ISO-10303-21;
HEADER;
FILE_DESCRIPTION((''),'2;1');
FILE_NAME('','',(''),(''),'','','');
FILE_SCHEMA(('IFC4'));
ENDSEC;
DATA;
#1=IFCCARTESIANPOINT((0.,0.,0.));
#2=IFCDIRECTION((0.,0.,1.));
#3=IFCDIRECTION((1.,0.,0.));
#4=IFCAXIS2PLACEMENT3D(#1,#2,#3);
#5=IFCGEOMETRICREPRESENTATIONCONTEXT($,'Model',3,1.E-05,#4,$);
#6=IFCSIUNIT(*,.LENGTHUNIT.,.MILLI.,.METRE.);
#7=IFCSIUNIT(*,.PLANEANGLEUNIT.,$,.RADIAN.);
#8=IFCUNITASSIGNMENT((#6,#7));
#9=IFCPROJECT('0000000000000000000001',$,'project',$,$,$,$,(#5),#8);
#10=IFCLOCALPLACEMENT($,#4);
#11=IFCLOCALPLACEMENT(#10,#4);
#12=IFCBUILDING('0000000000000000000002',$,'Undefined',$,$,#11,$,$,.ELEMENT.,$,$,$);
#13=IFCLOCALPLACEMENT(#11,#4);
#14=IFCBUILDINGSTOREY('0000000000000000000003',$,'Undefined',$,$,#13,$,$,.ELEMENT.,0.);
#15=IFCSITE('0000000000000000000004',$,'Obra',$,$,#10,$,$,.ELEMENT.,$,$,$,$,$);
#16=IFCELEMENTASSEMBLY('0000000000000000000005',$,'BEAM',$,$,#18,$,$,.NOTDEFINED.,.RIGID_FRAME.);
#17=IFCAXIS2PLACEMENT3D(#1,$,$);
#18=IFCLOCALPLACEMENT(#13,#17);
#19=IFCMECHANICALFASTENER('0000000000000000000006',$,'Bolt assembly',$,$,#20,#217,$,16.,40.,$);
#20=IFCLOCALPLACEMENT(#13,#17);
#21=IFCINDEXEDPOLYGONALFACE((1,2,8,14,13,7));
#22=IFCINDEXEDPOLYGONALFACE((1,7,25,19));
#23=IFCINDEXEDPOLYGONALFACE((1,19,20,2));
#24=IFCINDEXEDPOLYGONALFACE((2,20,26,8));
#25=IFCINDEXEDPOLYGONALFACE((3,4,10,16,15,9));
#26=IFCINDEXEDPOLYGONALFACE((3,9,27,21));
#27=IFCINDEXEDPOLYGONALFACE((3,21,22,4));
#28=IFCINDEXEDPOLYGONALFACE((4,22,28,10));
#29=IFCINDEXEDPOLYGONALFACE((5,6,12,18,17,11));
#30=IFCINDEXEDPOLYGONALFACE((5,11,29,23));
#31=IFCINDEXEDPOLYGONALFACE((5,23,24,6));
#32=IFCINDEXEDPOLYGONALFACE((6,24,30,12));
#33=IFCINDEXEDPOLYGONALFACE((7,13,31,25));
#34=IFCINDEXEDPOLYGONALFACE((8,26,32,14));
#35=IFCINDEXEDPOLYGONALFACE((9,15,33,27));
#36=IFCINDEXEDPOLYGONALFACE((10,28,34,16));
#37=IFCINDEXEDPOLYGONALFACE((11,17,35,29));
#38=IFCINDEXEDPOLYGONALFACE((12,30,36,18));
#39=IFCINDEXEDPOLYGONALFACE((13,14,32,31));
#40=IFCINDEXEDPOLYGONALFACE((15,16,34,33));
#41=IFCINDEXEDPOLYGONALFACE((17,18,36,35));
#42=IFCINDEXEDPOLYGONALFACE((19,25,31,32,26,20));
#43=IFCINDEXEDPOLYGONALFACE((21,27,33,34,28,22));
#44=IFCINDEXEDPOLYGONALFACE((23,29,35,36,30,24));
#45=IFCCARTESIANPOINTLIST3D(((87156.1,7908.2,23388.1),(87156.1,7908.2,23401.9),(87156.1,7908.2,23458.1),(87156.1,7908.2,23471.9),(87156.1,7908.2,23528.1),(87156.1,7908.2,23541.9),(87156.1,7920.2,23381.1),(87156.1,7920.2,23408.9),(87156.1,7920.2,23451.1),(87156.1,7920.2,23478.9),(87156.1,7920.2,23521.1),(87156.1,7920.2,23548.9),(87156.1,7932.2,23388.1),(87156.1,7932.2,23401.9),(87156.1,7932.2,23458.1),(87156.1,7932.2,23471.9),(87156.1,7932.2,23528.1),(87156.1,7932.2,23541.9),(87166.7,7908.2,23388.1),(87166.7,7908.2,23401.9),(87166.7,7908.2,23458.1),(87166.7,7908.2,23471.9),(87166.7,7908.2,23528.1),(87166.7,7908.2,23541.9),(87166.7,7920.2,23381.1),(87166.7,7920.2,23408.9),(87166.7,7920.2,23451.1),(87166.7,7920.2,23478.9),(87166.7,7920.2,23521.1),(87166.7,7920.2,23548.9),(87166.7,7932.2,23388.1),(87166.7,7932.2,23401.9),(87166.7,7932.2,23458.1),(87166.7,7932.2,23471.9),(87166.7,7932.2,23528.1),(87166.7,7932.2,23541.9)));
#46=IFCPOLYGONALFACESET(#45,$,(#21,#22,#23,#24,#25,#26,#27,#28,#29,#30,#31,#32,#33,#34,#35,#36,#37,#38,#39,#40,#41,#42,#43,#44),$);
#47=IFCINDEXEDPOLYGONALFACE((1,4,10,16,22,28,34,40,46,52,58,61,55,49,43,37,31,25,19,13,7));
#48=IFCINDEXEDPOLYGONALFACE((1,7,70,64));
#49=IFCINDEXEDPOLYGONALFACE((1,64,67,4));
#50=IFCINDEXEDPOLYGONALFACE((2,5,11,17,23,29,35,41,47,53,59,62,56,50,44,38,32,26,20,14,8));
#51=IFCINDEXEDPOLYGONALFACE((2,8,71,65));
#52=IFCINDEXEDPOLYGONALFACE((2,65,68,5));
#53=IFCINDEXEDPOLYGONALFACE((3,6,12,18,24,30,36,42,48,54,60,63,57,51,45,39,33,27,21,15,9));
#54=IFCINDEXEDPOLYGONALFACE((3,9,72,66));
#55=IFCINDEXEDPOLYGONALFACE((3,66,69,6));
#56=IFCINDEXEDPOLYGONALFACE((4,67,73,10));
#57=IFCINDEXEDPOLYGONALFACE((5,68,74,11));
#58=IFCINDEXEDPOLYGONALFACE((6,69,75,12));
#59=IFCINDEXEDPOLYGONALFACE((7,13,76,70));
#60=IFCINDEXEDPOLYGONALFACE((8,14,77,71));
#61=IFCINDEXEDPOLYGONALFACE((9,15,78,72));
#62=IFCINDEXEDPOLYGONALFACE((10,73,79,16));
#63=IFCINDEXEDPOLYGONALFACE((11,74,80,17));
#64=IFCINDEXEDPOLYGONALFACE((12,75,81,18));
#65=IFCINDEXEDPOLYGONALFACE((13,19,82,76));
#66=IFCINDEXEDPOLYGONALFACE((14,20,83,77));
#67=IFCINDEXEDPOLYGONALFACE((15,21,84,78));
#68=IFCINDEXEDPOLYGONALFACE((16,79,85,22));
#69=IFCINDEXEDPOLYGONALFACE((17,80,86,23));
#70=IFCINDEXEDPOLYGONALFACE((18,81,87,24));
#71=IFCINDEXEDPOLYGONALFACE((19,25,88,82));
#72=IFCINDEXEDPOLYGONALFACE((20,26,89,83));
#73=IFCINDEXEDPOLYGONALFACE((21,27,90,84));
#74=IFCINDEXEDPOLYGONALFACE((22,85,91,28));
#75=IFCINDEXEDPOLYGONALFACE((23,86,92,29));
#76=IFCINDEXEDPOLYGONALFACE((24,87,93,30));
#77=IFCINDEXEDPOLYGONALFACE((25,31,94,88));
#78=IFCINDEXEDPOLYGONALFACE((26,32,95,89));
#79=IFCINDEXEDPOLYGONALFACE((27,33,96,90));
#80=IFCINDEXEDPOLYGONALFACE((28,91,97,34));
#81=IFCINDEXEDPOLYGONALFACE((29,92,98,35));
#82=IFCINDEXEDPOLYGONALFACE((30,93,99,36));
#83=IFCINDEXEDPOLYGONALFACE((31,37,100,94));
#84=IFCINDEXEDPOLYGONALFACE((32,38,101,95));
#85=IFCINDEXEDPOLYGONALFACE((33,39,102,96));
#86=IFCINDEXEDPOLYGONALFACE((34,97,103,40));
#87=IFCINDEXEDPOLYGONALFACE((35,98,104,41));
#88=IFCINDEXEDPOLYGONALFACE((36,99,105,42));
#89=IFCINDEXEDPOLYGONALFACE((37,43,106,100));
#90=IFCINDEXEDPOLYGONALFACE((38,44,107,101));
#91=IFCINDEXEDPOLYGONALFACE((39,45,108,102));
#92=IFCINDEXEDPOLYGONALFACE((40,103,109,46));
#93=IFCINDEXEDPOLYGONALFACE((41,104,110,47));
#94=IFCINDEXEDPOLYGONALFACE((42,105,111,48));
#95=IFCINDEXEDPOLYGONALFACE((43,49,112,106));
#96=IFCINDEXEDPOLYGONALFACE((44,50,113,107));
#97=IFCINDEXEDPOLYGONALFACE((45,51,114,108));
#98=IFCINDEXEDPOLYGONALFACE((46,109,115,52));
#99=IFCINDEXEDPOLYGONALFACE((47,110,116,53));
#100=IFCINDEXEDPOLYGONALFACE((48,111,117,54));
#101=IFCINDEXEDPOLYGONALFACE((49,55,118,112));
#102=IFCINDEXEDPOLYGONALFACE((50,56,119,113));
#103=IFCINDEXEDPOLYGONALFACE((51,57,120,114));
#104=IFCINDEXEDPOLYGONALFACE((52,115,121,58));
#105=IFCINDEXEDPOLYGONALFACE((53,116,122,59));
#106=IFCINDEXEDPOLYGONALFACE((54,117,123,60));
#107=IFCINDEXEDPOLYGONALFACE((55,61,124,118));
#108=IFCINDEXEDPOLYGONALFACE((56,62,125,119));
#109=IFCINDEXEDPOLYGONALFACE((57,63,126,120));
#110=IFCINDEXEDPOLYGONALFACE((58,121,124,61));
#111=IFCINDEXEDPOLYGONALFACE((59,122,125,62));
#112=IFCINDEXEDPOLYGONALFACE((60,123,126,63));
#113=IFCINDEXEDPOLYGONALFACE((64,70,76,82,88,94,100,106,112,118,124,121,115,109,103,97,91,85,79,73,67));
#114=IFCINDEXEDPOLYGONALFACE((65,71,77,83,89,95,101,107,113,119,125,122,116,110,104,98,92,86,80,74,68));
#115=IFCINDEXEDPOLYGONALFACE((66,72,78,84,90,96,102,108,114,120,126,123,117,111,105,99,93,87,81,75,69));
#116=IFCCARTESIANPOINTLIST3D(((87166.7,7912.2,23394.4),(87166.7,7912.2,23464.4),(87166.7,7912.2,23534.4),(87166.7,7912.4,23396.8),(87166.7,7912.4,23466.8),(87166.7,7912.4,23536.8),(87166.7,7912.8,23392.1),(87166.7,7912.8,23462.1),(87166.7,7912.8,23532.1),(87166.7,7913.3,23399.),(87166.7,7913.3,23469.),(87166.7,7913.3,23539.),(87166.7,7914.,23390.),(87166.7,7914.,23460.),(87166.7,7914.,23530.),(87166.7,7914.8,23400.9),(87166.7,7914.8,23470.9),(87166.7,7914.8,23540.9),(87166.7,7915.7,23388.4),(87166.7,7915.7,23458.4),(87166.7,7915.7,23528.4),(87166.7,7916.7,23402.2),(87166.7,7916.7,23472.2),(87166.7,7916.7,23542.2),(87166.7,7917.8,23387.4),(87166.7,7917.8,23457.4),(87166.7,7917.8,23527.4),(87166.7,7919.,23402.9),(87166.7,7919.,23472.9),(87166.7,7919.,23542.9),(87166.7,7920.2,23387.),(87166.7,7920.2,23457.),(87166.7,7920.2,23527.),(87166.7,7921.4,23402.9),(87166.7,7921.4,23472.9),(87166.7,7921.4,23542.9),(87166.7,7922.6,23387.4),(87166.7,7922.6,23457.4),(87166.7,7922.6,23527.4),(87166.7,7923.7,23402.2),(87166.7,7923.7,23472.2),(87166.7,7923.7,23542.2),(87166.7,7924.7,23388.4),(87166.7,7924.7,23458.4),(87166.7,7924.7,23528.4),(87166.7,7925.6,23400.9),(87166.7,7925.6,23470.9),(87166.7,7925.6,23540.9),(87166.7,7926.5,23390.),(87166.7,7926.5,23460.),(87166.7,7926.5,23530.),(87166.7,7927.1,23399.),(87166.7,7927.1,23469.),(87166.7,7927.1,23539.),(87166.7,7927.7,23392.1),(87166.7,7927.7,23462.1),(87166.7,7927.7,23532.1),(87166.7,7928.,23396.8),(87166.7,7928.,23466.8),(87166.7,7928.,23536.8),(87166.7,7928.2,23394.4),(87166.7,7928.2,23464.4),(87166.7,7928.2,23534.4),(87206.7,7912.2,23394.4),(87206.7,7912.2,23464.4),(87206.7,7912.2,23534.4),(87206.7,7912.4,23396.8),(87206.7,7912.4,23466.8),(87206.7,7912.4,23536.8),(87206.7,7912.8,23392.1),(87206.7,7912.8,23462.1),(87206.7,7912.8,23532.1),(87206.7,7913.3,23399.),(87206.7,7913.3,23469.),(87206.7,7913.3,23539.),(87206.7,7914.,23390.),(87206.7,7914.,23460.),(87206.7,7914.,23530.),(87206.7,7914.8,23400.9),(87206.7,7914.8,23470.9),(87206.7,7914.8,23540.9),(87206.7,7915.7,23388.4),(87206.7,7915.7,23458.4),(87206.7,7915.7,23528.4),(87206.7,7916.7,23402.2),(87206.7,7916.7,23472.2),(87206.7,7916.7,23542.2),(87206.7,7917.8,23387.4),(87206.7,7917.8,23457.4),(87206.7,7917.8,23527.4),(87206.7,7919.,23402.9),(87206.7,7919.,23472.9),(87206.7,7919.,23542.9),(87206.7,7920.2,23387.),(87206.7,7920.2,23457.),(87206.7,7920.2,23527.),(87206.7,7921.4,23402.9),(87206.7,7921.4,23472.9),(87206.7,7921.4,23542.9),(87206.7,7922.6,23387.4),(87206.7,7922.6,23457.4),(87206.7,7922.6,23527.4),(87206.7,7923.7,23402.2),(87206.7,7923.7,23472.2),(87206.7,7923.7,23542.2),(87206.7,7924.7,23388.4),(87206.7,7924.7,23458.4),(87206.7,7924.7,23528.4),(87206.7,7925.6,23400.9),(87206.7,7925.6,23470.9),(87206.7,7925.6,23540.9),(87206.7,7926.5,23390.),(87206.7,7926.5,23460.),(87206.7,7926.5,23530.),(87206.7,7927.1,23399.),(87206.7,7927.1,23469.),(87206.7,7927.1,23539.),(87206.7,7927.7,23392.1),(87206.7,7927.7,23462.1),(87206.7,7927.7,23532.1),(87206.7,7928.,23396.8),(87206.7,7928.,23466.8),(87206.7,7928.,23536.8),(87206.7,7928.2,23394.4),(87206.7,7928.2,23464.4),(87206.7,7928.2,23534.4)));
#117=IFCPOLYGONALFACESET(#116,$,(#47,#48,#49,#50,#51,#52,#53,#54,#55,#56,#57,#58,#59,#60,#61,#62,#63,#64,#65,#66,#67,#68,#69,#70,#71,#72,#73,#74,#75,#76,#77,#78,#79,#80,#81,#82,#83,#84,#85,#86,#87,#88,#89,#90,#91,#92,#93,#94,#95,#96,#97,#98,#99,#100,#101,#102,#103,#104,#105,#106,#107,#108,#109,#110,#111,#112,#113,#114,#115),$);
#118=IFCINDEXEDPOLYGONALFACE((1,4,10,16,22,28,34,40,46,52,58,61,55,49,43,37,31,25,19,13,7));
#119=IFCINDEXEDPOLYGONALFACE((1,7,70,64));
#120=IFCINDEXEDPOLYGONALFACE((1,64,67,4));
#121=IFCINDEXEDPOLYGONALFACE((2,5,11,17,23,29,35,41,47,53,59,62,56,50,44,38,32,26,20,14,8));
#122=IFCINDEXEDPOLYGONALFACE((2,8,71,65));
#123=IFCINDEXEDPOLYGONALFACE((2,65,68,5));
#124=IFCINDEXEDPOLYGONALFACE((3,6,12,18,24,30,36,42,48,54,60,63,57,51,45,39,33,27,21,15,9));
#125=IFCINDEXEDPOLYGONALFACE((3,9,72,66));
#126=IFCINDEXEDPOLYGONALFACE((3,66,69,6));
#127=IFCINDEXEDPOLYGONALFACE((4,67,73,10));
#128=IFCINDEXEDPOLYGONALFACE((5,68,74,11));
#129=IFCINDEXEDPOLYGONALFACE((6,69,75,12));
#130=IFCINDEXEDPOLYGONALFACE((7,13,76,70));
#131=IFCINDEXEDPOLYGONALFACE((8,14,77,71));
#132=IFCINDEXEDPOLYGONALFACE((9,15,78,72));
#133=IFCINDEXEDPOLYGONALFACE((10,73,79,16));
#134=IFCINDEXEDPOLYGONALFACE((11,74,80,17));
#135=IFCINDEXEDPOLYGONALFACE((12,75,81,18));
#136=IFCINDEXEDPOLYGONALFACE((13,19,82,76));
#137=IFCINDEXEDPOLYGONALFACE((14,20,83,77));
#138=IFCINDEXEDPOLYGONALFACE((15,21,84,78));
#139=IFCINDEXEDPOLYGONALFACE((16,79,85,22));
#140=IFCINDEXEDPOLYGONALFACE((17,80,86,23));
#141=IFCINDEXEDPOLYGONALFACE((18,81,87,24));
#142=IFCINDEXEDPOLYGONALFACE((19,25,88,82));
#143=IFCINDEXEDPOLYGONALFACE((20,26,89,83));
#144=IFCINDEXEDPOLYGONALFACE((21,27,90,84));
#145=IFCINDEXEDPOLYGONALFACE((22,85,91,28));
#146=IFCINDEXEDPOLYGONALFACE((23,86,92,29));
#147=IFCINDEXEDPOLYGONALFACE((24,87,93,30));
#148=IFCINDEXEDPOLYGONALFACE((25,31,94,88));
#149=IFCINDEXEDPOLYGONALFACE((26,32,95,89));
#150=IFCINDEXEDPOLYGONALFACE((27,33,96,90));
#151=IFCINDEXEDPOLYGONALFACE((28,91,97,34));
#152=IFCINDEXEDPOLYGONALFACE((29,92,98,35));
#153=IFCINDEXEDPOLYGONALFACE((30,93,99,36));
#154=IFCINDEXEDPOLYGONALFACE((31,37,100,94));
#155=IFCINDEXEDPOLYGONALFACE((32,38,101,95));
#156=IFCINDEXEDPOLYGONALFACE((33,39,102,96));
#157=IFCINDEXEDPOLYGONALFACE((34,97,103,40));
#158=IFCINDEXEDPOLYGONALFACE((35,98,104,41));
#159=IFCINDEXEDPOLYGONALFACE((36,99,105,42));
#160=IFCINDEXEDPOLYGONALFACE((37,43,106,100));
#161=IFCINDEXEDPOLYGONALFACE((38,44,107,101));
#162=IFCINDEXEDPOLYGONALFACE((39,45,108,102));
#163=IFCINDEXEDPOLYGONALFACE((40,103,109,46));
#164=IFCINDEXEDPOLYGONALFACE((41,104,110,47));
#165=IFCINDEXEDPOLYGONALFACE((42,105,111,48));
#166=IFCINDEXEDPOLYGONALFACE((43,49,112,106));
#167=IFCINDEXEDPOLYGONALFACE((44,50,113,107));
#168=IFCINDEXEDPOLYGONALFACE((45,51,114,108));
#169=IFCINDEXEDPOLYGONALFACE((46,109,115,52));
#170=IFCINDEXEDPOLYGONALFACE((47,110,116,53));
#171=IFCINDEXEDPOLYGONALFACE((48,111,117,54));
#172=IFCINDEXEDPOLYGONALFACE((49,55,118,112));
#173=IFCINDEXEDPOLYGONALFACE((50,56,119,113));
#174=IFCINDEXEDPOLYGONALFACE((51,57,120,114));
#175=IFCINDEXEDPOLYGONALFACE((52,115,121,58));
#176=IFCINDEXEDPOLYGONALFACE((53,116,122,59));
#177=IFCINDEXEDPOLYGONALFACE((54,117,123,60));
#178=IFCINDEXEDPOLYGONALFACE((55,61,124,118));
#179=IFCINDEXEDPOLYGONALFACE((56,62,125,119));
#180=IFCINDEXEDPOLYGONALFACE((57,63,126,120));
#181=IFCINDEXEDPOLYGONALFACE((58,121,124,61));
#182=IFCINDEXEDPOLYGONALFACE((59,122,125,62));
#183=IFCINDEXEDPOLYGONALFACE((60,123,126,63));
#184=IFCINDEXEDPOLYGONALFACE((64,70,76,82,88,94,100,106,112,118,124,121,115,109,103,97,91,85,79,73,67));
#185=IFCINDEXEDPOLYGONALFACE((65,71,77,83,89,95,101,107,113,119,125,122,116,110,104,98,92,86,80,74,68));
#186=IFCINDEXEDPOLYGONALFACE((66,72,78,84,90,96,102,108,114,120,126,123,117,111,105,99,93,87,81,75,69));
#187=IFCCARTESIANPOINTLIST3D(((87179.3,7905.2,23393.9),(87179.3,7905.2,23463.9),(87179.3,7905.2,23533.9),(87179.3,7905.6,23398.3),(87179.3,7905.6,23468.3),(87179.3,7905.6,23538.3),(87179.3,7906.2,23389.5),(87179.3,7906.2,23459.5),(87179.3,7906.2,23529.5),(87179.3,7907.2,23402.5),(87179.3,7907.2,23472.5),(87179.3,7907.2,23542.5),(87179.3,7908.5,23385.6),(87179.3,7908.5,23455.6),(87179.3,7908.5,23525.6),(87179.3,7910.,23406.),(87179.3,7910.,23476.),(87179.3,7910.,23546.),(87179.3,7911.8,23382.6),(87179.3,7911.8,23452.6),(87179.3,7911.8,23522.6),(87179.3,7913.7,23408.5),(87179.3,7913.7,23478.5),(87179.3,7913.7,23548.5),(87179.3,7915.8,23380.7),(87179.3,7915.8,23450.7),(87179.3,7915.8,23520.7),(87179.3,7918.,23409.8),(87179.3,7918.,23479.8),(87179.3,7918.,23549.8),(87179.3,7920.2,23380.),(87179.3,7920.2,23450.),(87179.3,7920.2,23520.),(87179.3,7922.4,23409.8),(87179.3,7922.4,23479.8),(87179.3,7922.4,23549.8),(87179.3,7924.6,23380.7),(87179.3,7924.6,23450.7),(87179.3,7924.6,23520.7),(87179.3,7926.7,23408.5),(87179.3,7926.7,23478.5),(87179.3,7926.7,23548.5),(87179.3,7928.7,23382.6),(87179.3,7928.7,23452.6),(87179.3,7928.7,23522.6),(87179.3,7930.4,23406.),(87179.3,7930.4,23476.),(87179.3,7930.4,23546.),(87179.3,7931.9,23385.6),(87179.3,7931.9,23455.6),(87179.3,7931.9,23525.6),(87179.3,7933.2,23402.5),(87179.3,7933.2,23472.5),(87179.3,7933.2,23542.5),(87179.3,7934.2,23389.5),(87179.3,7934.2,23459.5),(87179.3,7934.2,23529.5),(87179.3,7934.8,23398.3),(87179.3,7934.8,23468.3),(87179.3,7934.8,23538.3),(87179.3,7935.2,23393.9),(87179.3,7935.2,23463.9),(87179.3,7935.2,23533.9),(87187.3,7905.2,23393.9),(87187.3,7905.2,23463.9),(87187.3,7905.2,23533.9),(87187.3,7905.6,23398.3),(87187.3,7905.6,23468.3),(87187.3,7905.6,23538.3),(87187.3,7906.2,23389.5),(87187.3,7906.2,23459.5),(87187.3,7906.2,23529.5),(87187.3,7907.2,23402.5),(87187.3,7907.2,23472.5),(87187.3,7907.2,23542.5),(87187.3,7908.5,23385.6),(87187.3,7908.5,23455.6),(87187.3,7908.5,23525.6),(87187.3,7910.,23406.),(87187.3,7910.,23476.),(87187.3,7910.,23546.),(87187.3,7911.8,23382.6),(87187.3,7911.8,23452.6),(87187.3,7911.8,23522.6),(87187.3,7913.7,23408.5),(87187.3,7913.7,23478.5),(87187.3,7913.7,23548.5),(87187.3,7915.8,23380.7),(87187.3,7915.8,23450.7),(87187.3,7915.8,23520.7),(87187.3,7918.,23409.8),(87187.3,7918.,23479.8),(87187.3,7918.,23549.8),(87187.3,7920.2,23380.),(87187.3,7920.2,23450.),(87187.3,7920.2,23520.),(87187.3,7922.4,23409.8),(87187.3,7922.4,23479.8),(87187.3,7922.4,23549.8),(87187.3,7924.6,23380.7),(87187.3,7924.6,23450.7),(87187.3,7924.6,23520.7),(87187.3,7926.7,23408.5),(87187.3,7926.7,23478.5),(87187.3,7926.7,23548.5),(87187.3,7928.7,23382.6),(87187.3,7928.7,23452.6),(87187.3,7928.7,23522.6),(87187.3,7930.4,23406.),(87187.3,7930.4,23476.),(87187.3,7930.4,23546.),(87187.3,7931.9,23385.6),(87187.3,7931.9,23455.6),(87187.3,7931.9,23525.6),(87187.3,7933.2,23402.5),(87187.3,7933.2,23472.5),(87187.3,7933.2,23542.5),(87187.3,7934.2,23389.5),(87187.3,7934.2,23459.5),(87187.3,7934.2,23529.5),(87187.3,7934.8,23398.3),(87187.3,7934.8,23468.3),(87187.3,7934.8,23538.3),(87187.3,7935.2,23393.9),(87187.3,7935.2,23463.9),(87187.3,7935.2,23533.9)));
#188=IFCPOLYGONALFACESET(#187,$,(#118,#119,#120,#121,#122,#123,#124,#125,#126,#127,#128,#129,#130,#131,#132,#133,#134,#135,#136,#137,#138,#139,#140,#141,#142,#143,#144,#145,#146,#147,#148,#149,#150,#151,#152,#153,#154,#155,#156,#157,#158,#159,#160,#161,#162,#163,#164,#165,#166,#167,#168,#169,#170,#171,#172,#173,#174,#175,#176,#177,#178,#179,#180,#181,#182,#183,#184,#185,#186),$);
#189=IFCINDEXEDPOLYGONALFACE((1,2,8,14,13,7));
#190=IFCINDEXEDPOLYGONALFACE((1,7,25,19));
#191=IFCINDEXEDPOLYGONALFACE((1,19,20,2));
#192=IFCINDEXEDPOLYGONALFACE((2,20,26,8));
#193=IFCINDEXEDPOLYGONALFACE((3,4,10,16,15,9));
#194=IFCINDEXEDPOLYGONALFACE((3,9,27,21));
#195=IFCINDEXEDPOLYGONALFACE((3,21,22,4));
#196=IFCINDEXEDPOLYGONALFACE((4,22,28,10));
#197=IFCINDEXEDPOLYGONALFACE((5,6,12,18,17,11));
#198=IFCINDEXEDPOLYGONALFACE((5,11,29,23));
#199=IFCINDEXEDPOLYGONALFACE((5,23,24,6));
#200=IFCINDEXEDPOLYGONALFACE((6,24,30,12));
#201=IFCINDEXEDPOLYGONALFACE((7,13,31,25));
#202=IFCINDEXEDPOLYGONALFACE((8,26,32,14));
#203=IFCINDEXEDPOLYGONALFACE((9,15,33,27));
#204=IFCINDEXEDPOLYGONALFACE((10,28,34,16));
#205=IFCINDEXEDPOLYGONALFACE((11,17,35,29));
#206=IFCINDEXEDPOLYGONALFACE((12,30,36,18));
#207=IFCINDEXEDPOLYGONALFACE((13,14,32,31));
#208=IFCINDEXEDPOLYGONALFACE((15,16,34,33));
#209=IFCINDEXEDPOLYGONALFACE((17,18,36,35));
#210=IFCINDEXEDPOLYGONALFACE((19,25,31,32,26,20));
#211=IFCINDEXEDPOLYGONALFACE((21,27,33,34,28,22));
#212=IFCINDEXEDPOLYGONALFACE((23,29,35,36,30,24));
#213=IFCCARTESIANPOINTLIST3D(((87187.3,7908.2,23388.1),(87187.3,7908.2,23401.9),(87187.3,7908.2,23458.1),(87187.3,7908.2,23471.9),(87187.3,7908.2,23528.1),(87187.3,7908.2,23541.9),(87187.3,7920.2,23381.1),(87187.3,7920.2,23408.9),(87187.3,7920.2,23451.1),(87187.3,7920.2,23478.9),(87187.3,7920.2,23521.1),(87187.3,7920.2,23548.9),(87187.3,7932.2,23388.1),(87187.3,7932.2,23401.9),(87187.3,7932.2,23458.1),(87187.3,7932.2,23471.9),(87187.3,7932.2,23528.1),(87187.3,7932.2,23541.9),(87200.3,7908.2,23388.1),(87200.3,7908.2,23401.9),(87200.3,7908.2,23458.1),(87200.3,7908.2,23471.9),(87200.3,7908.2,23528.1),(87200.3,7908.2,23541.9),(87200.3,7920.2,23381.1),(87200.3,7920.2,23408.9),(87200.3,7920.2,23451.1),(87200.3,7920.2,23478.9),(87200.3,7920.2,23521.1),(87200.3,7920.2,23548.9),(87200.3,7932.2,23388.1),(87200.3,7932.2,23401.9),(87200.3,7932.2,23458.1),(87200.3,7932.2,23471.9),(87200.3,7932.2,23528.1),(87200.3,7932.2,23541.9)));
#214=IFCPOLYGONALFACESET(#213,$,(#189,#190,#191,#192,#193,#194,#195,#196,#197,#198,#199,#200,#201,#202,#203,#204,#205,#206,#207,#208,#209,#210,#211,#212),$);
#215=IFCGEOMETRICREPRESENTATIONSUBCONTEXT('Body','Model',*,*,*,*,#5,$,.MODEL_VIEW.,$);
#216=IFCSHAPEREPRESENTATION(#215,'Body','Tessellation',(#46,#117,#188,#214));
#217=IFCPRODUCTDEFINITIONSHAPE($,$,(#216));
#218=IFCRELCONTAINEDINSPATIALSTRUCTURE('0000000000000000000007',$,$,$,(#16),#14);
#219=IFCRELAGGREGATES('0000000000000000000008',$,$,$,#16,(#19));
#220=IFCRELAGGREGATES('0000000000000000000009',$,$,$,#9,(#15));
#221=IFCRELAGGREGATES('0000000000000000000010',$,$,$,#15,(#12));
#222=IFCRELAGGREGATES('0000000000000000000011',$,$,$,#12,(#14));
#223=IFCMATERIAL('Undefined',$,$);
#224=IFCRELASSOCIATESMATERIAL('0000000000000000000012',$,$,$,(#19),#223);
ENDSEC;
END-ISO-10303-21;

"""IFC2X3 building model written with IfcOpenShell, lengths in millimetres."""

from ifc_helpers import new_model, si_unit, frame, origin_with_axes, origin_2d_with_axis, place, context, subcontext, project, spatial, polyline, circle, outline, extrude, source, transform, mapped, material, element, aggregate, save


model = new_model("IFC2X3")

# Units and contexts
model_context = context("Model", 3, precision=1e-05, world=origin_with_axes())
body_context = subcontext(model_context, "Body", "Model", "MODEL_VIEW")
ifc_project = project(units=[si_unit("LENGTHUNIT", "METRE", prefix="MILLI"), si_unit("PLANEANGLEUNIT", "RADIAN")], contexts=[model_context])

# Site, building, storey
site_placement = place(None, origin_with_axes())
site = spatial("IfcSite", under=ifc_project, at=site_placement, Name="Obra", CompositionType="ELEMENT")
building_placement = place(site_placement, origin_with_axes())
building = spatial("IfcBuilding", under=site, at=building_placement, Name="Undefined", CompositionType="ELEMENT")
storey_placement = place(building_placement, origin_with_axes())
storey = spatial("IfcBuildingStorey", under=building, at=storey_placement, Name="Undefined", CompositionType="ELEMENT", Elevation=0.0)

# Shared definitions
ifc_material_1 = material(Name="Undefined")

# Shared definitions
shared_shape_1 = source(origin_with_axes(), body_context, "Body", "SweptSolid", [
    extrude(outline(polyline([(13.9, 0.0), (6.9, 12.0), (-6.9, 12.0), (-13.9, 0.0), (-6.9, -12.0), (6.9, -12.0), (13.9, 0.0)])), frame((0.0, -13.9, 0.0), z_axis=(0.0, 1.0, 0.0), x_axis=(1.0, 0.0, 0.0)), (0.0, 0.0, 1.0), 10.6),
    extrude(circle(Radius=8.0, at=origin_2d_with_axis()), frame((0.0, -3.3, 0.0), z_axis=(0.0, 1.0, 0.0), x_axis=(1.0, 0.0, 0.0)), (0.0, 0.0, 1.0), 40.0),
    extrude(circle(Radius=15.0, at=origin_2d_with_axis()), frame((0.0, 9.3, 0.0), z_axis=(0.0, 1.0, 0.0), x_axis=(1.0, 0.0, 0.0)), (0.0, 0.0, 1.0), 8.0),
    extrude(outline(polyline([(13.9, 0.0), (6.9, 12.0), (-6.9, 12.0), (-13.9, 0.0), (-6.9, -12.0), (6.9, -12.0), (13.9, 0.0)])), frame((0.0, 17.3, 0.0), z_axis=(0.0, 1.0, 0.0), x_axis=(1.0, 0.0, 0.0)), (0.0, 0.0, 1.0), 13.0),
])

# Element assembly, mechanical fastener
assembly_1_placement = place(storey_placement, origin_with_axes())
assembly_1 = element("IfcElementAssembly", 1, at=assembly_1_placement, inside=storey, Name="BEAM", AssemblyPlace="NOTDEFINED", PredefinedType="RIGID_FRAME")
mechanical_fastener_1_placement = place(assembly_1_placement, frame((87170.0, 7960.2, 23570.0), z_axis=(0.0, -1.0, 0.0), x_axis=(0.0, 0.0, -1.0)))
mechanical_fastener_1 = element("IfcMechanicalFastener", 2, at=mechanical_fastener_1_placement, material=ifc_material_1, Name="Bolt assembly", NominalDiameter=16.0, NominalLength=40.0, context=body_context, shape_type="MappedRepresentation", body=[
    mapped(shared_shape_1, transform((35.0, 0.0, 40.0))),
    mapped(shared_shape_1, transform((105.0, 0.0, 40.0))),
    mapped(shared_shape_1, transform((175.0, 0.0, 40.0))),
])
aggregate(assembly_1, [mechanical_fastener_1])

save(model, "model.ifc")
